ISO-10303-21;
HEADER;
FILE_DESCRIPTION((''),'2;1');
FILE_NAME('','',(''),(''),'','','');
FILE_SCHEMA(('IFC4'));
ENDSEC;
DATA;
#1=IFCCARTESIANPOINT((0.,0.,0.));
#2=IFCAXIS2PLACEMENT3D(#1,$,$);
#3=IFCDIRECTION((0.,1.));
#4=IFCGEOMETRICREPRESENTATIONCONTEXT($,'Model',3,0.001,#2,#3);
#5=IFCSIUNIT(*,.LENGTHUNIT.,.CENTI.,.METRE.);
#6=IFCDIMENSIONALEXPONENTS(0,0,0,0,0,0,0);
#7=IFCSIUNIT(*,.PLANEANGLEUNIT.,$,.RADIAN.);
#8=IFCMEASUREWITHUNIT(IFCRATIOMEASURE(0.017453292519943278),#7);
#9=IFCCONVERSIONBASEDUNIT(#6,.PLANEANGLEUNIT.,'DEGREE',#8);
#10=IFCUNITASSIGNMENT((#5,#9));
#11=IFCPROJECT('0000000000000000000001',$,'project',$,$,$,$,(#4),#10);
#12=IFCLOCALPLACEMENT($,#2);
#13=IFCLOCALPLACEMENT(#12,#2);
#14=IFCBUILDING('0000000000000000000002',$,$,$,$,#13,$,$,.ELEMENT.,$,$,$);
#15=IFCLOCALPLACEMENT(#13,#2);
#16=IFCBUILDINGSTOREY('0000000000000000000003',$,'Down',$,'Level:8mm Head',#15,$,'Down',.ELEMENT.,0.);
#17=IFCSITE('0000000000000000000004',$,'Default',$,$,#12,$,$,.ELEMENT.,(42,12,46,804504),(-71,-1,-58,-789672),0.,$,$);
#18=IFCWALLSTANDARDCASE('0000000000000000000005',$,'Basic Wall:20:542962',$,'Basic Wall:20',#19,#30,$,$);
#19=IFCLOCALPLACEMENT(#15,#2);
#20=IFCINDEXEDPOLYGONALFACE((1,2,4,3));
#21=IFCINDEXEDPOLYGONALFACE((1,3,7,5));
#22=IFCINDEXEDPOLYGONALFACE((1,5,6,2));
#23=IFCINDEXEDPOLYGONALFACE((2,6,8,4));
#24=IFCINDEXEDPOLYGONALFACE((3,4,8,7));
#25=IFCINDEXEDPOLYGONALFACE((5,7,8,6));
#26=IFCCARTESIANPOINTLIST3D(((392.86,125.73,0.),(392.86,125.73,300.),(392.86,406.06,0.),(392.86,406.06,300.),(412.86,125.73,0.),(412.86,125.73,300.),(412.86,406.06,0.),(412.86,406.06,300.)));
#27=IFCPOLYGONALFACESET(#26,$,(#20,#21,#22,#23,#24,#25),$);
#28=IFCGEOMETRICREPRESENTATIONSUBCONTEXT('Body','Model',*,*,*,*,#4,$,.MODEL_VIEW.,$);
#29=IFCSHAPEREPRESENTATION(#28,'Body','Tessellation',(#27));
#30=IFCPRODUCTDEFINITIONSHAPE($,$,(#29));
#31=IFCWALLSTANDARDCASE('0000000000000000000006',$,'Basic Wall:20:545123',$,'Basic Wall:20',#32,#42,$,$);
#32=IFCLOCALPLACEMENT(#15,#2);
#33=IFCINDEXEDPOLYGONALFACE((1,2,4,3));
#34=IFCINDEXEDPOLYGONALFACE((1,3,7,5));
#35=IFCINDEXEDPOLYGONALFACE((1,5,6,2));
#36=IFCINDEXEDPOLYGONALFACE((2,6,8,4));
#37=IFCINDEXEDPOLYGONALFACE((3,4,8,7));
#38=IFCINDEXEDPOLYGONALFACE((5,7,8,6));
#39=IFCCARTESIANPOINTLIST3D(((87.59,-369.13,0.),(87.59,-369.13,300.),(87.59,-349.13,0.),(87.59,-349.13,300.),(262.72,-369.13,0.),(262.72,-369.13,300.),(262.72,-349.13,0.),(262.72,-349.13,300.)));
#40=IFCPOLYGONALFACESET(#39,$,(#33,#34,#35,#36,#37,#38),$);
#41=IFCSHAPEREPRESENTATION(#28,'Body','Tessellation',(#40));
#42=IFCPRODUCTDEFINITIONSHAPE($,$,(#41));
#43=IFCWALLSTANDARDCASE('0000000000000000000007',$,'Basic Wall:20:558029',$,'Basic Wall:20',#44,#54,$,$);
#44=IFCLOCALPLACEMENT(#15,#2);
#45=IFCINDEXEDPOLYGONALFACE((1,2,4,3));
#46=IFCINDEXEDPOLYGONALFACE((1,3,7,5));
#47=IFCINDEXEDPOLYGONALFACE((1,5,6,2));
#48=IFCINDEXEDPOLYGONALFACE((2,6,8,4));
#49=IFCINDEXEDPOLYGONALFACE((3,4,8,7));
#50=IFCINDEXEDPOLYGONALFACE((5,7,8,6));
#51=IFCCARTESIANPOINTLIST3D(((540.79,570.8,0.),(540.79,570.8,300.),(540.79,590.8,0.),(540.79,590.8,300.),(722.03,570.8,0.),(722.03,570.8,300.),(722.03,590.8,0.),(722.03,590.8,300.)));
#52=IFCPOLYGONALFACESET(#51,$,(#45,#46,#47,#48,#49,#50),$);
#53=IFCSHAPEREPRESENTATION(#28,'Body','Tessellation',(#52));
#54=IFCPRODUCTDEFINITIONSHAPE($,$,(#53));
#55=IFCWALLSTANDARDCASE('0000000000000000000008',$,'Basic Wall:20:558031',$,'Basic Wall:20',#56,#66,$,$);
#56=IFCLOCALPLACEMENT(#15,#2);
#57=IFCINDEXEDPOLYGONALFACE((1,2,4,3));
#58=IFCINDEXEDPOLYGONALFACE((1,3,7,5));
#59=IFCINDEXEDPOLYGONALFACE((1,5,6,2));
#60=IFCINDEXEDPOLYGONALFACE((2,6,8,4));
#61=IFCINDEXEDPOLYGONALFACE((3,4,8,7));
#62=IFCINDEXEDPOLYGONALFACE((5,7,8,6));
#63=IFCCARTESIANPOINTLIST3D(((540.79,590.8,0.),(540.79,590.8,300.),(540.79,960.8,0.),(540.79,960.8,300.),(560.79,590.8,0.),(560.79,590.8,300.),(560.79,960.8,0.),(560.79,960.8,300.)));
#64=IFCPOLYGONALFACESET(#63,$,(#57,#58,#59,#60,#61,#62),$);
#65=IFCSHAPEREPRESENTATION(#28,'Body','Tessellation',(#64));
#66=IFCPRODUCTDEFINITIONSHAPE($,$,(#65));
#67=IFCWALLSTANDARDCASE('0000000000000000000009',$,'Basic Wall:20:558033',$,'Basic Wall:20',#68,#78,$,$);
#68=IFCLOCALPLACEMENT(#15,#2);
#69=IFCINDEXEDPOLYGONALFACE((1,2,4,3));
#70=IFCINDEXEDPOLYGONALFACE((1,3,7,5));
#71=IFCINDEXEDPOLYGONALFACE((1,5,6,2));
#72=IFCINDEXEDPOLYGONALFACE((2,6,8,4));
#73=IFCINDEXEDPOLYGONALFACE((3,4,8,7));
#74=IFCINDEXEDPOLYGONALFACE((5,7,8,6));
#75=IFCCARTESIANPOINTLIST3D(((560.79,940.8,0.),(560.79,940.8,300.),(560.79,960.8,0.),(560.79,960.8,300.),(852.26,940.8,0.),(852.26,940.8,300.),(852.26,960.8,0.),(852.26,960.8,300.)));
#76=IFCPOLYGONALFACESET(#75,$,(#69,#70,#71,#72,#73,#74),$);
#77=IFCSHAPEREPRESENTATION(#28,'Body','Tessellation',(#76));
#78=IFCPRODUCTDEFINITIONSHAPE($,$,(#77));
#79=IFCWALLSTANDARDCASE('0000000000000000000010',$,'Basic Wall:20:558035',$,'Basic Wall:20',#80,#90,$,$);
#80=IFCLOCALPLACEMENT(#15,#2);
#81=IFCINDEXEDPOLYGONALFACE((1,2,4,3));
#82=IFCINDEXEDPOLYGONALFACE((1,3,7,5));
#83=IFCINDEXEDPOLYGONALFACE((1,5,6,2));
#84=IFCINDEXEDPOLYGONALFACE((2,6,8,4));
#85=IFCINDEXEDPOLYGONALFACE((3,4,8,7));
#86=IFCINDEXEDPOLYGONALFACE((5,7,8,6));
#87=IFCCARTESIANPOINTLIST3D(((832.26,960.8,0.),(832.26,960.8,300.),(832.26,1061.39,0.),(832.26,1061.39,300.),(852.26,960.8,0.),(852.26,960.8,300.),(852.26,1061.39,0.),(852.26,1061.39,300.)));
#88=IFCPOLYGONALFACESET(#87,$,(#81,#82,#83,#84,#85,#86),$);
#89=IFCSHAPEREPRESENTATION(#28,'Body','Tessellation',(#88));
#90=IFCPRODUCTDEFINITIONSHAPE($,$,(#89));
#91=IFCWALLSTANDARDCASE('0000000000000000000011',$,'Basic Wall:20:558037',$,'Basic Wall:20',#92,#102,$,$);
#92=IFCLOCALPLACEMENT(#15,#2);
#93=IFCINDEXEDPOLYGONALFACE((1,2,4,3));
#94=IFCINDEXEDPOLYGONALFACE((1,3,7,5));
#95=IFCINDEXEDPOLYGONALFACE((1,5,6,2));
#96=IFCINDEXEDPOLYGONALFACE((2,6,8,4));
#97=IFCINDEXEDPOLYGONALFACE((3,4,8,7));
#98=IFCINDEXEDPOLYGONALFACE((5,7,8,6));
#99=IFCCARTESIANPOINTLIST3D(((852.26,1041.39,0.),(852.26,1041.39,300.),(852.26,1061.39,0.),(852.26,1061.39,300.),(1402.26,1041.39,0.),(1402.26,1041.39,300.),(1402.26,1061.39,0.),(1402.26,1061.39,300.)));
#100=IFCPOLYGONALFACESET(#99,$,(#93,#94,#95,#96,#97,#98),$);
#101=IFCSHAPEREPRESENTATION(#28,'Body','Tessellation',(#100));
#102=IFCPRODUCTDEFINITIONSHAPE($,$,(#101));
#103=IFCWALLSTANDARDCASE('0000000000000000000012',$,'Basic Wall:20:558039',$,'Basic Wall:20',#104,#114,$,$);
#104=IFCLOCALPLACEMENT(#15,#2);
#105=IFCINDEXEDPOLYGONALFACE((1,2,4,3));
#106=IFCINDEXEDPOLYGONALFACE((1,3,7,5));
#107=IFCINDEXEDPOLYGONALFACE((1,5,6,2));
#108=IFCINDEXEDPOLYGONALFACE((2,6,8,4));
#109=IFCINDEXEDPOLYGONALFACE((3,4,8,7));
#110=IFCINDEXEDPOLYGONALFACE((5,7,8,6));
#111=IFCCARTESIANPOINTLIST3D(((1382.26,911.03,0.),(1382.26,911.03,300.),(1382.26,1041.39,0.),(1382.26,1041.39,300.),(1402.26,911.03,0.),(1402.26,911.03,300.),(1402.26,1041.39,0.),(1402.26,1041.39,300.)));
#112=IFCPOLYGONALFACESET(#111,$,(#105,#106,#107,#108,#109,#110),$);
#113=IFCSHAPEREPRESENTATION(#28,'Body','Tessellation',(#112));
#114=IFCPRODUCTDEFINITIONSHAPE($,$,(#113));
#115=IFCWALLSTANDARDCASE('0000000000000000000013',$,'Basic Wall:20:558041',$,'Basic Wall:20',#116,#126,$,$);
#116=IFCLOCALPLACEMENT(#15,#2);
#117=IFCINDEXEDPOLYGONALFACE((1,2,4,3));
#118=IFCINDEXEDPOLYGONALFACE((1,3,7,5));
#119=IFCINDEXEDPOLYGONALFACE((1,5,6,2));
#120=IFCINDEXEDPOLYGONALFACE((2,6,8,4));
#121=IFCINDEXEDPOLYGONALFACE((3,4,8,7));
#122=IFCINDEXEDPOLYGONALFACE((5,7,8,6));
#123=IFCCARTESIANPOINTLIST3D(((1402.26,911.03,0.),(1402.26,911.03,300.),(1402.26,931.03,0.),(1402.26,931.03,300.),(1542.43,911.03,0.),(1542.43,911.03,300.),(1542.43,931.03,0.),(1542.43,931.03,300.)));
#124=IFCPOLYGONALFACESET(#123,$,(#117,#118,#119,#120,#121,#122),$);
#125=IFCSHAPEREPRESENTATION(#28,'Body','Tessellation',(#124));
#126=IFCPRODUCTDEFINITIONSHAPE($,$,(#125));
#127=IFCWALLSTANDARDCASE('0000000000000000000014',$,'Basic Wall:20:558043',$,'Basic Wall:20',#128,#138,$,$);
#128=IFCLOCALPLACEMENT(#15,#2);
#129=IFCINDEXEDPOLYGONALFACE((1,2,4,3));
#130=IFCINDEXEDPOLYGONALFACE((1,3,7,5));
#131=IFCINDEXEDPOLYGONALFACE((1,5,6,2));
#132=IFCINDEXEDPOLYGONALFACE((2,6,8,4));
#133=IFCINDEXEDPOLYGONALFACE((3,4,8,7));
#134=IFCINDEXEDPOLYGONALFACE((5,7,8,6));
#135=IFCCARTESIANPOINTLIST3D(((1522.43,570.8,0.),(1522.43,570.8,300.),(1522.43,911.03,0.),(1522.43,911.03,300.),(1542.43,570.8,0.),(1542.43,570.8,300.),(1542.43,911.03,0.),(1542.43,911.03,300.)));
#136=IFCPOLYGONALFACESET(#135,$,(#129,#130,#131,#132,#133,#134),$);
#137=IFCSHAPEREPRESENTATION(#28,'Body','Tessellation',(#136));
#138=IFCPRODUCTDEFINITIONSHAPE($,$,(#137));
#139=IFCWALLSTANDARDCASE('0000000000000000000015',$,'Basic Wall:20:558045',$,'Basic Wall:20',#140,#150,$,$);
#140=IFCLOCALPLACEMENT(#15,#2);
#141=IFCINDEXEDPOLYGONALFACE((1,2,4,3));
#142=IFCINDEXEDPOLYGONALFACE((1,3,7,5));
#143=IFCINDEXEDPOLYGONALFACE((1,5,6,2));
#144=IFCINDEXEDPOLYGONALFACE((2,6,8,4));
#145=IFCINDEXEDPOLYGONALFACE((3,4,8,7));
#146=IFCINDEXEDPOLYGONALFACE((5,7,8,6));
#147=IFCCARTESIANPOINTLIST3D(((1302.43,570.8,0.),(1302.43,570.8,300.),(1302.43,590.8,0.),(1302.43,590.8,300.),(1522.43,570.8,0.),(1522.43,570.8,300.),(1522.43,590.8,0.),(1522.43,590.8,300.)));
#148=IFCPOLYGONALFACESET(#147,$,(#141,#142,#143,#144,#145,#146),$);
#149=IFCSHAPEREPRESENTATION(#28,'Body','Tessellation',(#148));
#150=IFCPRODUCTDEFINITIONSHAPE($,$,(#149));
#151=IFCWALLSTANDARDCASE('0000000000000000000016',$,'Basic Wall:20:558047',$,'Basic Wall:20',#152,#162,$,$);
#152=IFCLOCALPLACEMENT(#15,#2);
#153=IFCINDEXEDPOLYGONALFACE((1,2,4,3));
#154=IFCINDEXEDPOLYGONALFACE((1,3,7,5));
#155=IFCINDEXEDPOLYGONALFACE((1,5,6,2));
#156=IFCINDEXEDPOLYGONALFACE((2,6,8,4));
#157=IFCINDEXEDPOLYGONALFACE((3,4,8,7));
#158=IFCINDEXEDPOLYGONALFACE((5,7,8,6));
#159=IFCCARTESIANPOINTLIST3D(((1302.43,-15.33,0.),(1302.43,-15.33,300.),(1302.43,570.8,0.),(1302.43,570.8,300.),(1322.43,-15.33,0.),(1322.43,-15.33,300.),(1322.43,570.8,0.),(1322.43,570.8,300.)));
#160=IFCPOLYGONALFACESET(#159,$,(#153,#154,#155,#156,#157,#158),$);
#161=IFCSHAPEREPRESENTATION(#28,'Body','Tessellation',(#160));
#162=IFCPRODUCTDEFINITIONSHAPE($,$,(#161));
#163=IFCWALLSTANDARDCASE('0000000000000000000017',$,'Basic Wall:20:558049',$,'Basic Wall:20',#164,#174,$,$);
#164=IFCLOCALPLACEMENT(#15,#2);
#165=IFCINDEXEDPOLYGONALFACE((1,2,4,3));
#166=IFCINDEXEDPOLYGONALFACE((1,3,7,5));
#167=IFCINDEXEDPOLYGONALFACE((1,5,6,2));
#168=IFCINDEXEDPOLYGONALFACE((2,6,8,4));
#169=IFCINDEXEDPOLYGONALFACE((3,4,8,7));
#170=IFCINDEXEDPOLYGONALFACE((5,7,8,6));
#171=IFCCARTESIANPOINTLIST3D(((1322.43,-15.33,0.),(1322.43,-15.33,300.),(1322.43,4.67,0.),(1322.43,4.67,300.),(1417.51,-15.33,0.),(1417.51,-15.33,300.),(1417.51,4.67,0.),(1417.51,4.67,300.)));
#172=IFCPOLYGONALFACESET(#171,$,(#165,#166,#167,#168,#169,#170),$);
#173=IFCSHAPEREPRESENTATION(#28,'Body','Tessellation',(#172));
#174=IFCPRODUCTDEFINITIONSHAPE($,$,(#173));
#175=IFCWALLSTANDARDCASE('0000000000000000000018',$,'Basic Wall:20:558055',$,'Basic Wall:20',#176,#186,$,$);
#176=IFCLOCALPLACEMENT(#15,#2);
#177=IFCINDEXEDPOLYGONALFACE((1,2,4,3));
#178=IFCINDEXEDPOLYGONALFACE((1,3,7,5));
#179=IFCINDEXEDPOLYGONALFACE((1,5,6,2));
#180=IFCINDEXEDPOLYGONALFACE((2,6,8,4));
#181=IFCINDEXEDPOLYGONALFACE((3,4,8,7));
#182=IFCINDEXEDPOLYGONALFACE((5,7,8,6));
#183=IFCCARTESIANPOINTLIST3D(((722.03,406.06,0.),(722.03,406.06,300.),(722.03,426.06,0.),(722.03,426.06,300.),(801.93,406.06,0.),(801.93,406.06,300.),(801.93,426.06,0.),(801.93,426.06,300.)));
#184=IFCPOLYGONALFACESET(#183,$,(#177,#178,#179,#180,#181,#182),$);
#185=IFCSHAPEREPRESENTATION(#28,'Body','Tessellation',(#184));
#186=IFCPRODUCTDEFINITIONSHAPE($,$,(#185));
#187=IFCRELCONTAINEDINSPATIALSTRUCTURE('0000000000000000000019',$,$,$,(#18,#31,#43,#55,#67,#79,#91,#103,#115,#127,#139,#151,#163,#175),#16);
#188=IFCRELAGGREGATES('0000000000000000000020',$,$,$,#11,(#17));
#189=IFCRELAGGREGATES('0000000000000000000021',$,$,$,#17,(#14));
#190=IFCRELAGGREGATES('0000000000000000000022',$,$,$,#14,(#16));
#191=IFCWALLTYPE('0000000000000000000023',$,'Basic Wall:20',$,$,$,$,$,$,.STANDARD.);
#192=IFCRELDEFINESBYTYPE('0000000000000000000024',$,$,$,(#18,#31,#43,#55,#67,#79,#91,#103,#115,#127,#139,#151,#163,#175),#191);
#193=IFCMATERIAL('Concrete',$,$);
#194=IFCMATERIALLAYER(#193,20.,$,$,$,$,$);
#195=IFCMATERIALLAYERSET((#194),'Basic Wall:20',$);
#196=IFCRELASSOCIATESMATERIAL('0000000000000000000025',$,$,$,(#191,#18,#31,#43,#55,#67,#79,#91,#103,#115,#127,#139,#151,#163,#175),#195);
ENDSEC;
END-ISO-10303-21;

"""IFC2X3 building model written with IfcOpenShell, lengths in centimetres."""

from ifc_helpers import new_model, entity, si_unit, converted_unit, direction, frame, frame_2d, origin, place, context, subcontext, project, spatial, rectangle, extrude, material, layer, layer_set, layer_usage, type_object, element, save


model = new_model("IFC2X3")

# Units and contexts
model_context = context("Model", 3, precision=0.001, world=origin(), true_north=direction((0.0, 1.0)))
body_context = subcontext(model_context, "Body", "Model", "MODEL_VIEW")
ifc_project = project(units=[si_unit("LENGTHUNIT", "METRE", prefix="CENTI"), converted_unit("PLANEANGLEUNIT", "DEGREE", entity("IfcRatioMeasure", 0.017453292519943278), si_unit("PLANEANGLEUNIT", "RADIAN"), dimensions=[0, 0, 0, 0, 0, 0, 0])], contexts=[model_context])

# Site, building, storey
site_placement = place(None, origin())
site = spatial("IfcSite", under=ifc_project, at=site_placement, Name="Default", CompositionType="ELEMENT", RefLatitude=(42, 12, 46, 804504), RefLongitude=(-71, -1, -58, -789672), RefElevation=0.0)
building_placement = place(site_placement, origin())
building = spatial("IfcBuilding", under=site, at=building_placement, CompositionType="ELEMENT")
storey_placement = place(building_placement, origin())
storey = spatial("IfcBuildingStorey", under=building, at=storey_placement, Name="Down", ObjectType="Level:8mm Head", LongName="Down", CompositionType="ELEMENT", Elevation=0.0)

# Walls
ifc_material = material(Name="Concrete")
ifc_layer_1 = layer(ifc_material, 20.0)
ifc_layer_set_1 = layer_set([ifc_layer_1], Name="Basic Wall:20")
ifc_layer_usage_1 = layer_usage(ifc_layer_set_1, "AXIS2", "POSITIVE", -10.0)
wall_type_1 = type_object("IfcWallType", Name="Basic Wall:20", PredefinedType="STANDARD", material=ifc_layer_set_1)
wall_1_placement = place(storey_placement, frame((402.86, 125.73, 0.0), z_axis=(0.0, 0.0, 1.0), x_axis=(0.0, 1.0, 0.0)))
element("IfcWallStandardCase", 1, at=wall_1_placement, inside=storey, type_object=wall_type_1, material=ifc_layer_usage_1, Name="Basic Wall:20:542962", ObjectType="Basic Wall:20", context=body_context, shape_type="SweptSolid", body=[
    extrude(rectangle(XDim=280.33, YDim=20.0, at=frame_2d((140.17, 0.0), x_axis=(-1.0, 0.0))), origin(), (0.0, 0.0, 1.0), 300.0),
])
ifc_layer_usage_2 = layer_usage(ifc_layer_set_1, "AXIS2", "POSITIVE", -10.0)
wall_2_placement = place(storey_placement, frame((262.72, -359.13, 0.0), z_axis=(0.0, 0.0, 1.0), x_axis=(-1.0, 0.0, 0.0)))
element("IfcWallStandardCase", 2, at=wall_2_placement, inside=storey, type_object=wall_type_1, material=ifc_layer_usage_2, Name="Basic Wall:20:545123", ObjectType="Basic Wall:20", context=body_context, shape_type="SweptSolid", body=[
    extrude(rectangle(XDim=175.13, YDim=20.0, at=frame_2d((87.57, 0.0), x_axis=(-1.0, 0.0))), origin(), (0.0, 0.0, 1.0), 300.0),
])
ifc_layer_usage_3 = layer_usage(ifc_layer_set_1, "AXIS2", "POSITIVE", -10.0)
wall_3_placement = place(storey_placement, frame((722.03, 580.8, 0.0), z_axis=(0.0, 0.0, 1.0), x_axis=(-1.0, 0.0, 0.0)))
element("IfcWallStandardCase", 3, at=wall_3_placement, inside=storey, type_object=wall_type_1, material=ifc_layer_usage_3, Name="Basic Wall:20:558029", ObjectType="Basic Wall:20", context=body_context, shape_type="SweptSolid", body=[
    extrude(rectangle(XDim=181.24, YDim=20.0, at=frame_2d((90.62, 0.0), x_axis=(-1.0, 0.0))), origin(), (0.0, 0.0, 1.0), 300.0),
])
ifc_layer_usage_4 = layer_usage(ifc_layer_set_1, "AXIS2", "NEGATIVE", 10.0)
wall_4_placement = place(storey_placement, frame((550.79, 590.8, 0.0), z_axis=(0.0, 0.0, 1.0), x_axis=(0.0, 1.0, 0.0)))
element("IfcWallStandardCase", 4, at=wall_4_placement, inside=storey, type_object=wall_type_1, material=ifc_layer_usage_4, Name="Basic Wall:20:558031", ObjectType="Basic Wall:20", context=body_context, shape_type="SweptSolid", body=[
    extrude(rectangle(XDim=370.0, YDim=20.0, at=frame_2d((185.0, 0.0), x_axis=(-1.0, 0.0))), origin(), (0.0, 0.0, 1.0), 300.0),
])
ifc_layer_usage_5 = layer_usage(ifc_layer_set_1, "AXIS2", "NEGATIVE", 10.0)
wall_5_placement = place(storey_placement, frame((560.79, 950.8, 0.0)))
element("IfcWallStandardCase", 5, at=wall_5_placement, inside=storey, type_object=wall_type_1, material=ifc_layer_usage_5, Name="Basic Wall:20:558033", ObjectType="Basic Wall:20", context=body_context, shape_type="SweptSolid", body=[
    extrude(rectangle(XDim=291.47, YDim=20.0, at=frame_2d((145.73, 0.0), x_axis=(-1.0, 0.0))), origin(), (0.0, 0.0, 1.0), 300.0),
])
ifc_layer_usage_6 = layer_usage(ifc_layer_set_1, "AXIS2", "POSITIVE", -10.0)
wall_6_placement = place(storey_placement, frame((842.26, 960.8, 0.0), z_axis=(0.0, 0.0, 1.0), x_axis=(0.0, 1.0, 0.0)))
element("IfcWallStandardCase", 6, at=wall_6_placement, inside=storey, type_object=wall_type_1, material=ifc_layer_usage_6, Name="Basic Wall:20:558035", ObjectType="Basic Wall:20", context=body_context, shape_type="SweptSolid", body=[
    extrude(rectangle(XDim=100.6, YDim=20.0, at=frame_2d((50.3, 0.0), x_axis=(-1.0, 0.0))), origin(), (0.0, 0.0, 1.0), 300.0),
])
ifc_layer_usage_7 = layer_usage(ifc_layer_set_1, "AXIS2", "NEGATIVE", 10.0)
wall_7_placement = place(storey_placement, frame((852.26, 1051.39, 0.0)))
element("IfcWallStandardCase", 7, at=wall_7_placement, inside=storey, type_object=wall_type_1, material=ifc_layer_usage_7, Name="Basic Wall:20:558037", ObjectType="Basic Wall:20", context=body_context, shape_type="SweptSolid", body=[
    extrude(rectangle(XDim=550.0, YDim=20.0, at=frame_2d((275.0, 0.0), x_axis=(-1.0, 0.0))), origin(), (0.0, 0.0, 1.0), 300.0),
])
ifc_layer_usage_8 = layer_usage(ifc_layer_set_1, "AXIS2", "NEGATIVE", 10.0)
wall_8_placement = place(storey_placement, frame((1392.26, 1041.39, 0.0), z_axis=(0.0, 0.0, 1.0), x_axis=(0.0, -1.0, 0.0)))
element("IfcWallStandardCase", 8, at=wall_8_placement, inside=storey, type_object=wall_type_1, material=ifc_layer_usage_8, Name="Basic Wall:20:558039", ObjectType="Basic Wall:20", context=body_context, shape_type="SweptSolid", body=[
    extrude(rectangle(XDim=130.36, YDim=20.0, at=frame_2d((65.18, 0.0), x_axis=(-1.0, 0.0))), origin(), (0.0, 0.0, 1.0), 300.0),
])
ifc_layer_usage_9 = layer_usage(ifc_layer_set_1, "AXIS2", "POSITIVE", -10.0)
wall_9_placement = place(storey_placement, frame((1402.26, 921.03, 0.0)))
element("IfcWallStandardCase", 9, at=wall_9_placement, inside=storey, type_object=wall_type_1, material=ifc_layer_usage_9, Name="Basic Wall:20:558041", ObjectType="Basic Wall:20", context=body_context, shape_type="SweptSolid", body=[
    extrude(rectangle(XDim=140.17, YDim=20.0, at=frame_2d((70.08, 0.0), x_axis=(-1.0, 0.0))), origin(), (0.0, 0.0, 1.0), 300.0),
])
ifc_layer_usage_10 = layer_usage(ifc_layer_set_1, "AXIS2", "NEGATIVE", 10.0)
wall_10_placement = place(storey_placement, frame((1532.43, 911.03, 0.0), z_axis=(0.0, 0.0, 1.0), x_axis=(0.0, -1.0, 0.0)))
element("IfcWallStandardCase", 10, at=wall_10_placement, inside=storey, type_object=wall_type_1, material=ifc_layer_usage_10, Name="Basic Wall:20:558043", ObjectType="Basic Wall:20", context=body_context, shape_type="SweptSolid", body=[
    extrude(rectangle(XDim=340.23, YDim=20.0, at=frame_2d((170.12, 0.0), x_axis=(-1.0, 0.0))), origin(), (0.0, 0.0, 1.0), 300.0),
])
ifc_layer_usage_11 = layer_usage(ifc_layer_set_1, "AXIS2", "NEGATIVE", 10.0)
wall_11_placement = place(storey_placement, frame((1522.43, 580.8, 0.0), z_axis=(0.0, 0.0, 1.0), x_axis=(-1.0, 0.0, 0.0)))
element("IfcWallStandardCase", 11, at=wall_11_placement, inside=storey, type_object=wall_type_1, material=ifc_layer_usage_11, Name="Basic Wall:20:558045", ObjectType="Basic Wall:20", context=body_context, shape_type="SweptSolid", body=[
    extrude(rectangle(XDim=220.0, YDim=20.0, at=frame_2d((110.0, 0.0), x_axis=(-1.0, 0.0))), origin(), (0.0, 0.0, 1.0), 300.0),
])
ifc_layer_usage_12 = layer_usage(ifc_layer_set_1, "AXIS2", "POSITIVE", -10.0)
wall_12_placement = place(storey_placement, frame((1312.43, 570.8, 0.0), z_axis=(0.0, 0.0, 1.0), x_axis=(0.0, -1.0, 0.0)))
element("IfcWallStandardCase", 12, at=wall_12_placement, inside=storey, type_object=wall_type_1, material=ifc_layer_usage_12, Name="Basic Wall:20:558047", ObjectType="Basic Wall:20", context=body_context, shape_type="SweptSolid", body=[
    extrude(rectangle(XDim=586.13, YDim=20.0, at=frame_2d((293.07, 0.0), x_axis=(-1.0, 0.0))), origin(), (0.0, 0.0, 1.0), 300.0),
])
ifc_layer_usage_13 = layer_usage(ifc_layer_set_1, "AXIS2", "POSITIVE", -10.0)
wall_13_placement = place(storey_placement, frame((1322.43, -5.33, 0.0)))
element("IfcWallStandardCase", 13, at=wall_13_placement, inside=storey, type_object=wall_type_1, material=ifc_layer_usage_13, Name="Basic Wall:20:558049", ObjectType="Basic Wall:20", context=body_context, shape_type="SweptSolid", body=[
    extrude(rectangle(XDim=95.09, YDim=20.0, at=frame_2d((47.54, 0.0), x_axis=(-1.0, 0.0))), origin(), (0.0, 0.0, 1.0), 300.0),
])
ifc_layer_usage_14 = layer_usage(ifc_layer_set_1, "AXIS2", "POSITIVE", -10.0)
wall_14_placement = place(storey_placement, frame((722.03, 416.06, 0.0)))
element("IfcWallStandardCase", 14, at=wall_14_placement, inside=storey, type_object=wall_type_1, material=ifc_layer_usage_14, Name="Basic Wall:20:558055", ObjectType="Basic Wall:20", context=body_context, shape_type="SweptSolid", body=[
    extrude(rectangle(XDim=79.9, YDim=20.0, at=frame_2d((39.95, 0.0), x_axis=(-1.0, 0.0))), origin(), (0.0, 0.0, 1.0), 300.0),
])

save(model, "model.ifc")
